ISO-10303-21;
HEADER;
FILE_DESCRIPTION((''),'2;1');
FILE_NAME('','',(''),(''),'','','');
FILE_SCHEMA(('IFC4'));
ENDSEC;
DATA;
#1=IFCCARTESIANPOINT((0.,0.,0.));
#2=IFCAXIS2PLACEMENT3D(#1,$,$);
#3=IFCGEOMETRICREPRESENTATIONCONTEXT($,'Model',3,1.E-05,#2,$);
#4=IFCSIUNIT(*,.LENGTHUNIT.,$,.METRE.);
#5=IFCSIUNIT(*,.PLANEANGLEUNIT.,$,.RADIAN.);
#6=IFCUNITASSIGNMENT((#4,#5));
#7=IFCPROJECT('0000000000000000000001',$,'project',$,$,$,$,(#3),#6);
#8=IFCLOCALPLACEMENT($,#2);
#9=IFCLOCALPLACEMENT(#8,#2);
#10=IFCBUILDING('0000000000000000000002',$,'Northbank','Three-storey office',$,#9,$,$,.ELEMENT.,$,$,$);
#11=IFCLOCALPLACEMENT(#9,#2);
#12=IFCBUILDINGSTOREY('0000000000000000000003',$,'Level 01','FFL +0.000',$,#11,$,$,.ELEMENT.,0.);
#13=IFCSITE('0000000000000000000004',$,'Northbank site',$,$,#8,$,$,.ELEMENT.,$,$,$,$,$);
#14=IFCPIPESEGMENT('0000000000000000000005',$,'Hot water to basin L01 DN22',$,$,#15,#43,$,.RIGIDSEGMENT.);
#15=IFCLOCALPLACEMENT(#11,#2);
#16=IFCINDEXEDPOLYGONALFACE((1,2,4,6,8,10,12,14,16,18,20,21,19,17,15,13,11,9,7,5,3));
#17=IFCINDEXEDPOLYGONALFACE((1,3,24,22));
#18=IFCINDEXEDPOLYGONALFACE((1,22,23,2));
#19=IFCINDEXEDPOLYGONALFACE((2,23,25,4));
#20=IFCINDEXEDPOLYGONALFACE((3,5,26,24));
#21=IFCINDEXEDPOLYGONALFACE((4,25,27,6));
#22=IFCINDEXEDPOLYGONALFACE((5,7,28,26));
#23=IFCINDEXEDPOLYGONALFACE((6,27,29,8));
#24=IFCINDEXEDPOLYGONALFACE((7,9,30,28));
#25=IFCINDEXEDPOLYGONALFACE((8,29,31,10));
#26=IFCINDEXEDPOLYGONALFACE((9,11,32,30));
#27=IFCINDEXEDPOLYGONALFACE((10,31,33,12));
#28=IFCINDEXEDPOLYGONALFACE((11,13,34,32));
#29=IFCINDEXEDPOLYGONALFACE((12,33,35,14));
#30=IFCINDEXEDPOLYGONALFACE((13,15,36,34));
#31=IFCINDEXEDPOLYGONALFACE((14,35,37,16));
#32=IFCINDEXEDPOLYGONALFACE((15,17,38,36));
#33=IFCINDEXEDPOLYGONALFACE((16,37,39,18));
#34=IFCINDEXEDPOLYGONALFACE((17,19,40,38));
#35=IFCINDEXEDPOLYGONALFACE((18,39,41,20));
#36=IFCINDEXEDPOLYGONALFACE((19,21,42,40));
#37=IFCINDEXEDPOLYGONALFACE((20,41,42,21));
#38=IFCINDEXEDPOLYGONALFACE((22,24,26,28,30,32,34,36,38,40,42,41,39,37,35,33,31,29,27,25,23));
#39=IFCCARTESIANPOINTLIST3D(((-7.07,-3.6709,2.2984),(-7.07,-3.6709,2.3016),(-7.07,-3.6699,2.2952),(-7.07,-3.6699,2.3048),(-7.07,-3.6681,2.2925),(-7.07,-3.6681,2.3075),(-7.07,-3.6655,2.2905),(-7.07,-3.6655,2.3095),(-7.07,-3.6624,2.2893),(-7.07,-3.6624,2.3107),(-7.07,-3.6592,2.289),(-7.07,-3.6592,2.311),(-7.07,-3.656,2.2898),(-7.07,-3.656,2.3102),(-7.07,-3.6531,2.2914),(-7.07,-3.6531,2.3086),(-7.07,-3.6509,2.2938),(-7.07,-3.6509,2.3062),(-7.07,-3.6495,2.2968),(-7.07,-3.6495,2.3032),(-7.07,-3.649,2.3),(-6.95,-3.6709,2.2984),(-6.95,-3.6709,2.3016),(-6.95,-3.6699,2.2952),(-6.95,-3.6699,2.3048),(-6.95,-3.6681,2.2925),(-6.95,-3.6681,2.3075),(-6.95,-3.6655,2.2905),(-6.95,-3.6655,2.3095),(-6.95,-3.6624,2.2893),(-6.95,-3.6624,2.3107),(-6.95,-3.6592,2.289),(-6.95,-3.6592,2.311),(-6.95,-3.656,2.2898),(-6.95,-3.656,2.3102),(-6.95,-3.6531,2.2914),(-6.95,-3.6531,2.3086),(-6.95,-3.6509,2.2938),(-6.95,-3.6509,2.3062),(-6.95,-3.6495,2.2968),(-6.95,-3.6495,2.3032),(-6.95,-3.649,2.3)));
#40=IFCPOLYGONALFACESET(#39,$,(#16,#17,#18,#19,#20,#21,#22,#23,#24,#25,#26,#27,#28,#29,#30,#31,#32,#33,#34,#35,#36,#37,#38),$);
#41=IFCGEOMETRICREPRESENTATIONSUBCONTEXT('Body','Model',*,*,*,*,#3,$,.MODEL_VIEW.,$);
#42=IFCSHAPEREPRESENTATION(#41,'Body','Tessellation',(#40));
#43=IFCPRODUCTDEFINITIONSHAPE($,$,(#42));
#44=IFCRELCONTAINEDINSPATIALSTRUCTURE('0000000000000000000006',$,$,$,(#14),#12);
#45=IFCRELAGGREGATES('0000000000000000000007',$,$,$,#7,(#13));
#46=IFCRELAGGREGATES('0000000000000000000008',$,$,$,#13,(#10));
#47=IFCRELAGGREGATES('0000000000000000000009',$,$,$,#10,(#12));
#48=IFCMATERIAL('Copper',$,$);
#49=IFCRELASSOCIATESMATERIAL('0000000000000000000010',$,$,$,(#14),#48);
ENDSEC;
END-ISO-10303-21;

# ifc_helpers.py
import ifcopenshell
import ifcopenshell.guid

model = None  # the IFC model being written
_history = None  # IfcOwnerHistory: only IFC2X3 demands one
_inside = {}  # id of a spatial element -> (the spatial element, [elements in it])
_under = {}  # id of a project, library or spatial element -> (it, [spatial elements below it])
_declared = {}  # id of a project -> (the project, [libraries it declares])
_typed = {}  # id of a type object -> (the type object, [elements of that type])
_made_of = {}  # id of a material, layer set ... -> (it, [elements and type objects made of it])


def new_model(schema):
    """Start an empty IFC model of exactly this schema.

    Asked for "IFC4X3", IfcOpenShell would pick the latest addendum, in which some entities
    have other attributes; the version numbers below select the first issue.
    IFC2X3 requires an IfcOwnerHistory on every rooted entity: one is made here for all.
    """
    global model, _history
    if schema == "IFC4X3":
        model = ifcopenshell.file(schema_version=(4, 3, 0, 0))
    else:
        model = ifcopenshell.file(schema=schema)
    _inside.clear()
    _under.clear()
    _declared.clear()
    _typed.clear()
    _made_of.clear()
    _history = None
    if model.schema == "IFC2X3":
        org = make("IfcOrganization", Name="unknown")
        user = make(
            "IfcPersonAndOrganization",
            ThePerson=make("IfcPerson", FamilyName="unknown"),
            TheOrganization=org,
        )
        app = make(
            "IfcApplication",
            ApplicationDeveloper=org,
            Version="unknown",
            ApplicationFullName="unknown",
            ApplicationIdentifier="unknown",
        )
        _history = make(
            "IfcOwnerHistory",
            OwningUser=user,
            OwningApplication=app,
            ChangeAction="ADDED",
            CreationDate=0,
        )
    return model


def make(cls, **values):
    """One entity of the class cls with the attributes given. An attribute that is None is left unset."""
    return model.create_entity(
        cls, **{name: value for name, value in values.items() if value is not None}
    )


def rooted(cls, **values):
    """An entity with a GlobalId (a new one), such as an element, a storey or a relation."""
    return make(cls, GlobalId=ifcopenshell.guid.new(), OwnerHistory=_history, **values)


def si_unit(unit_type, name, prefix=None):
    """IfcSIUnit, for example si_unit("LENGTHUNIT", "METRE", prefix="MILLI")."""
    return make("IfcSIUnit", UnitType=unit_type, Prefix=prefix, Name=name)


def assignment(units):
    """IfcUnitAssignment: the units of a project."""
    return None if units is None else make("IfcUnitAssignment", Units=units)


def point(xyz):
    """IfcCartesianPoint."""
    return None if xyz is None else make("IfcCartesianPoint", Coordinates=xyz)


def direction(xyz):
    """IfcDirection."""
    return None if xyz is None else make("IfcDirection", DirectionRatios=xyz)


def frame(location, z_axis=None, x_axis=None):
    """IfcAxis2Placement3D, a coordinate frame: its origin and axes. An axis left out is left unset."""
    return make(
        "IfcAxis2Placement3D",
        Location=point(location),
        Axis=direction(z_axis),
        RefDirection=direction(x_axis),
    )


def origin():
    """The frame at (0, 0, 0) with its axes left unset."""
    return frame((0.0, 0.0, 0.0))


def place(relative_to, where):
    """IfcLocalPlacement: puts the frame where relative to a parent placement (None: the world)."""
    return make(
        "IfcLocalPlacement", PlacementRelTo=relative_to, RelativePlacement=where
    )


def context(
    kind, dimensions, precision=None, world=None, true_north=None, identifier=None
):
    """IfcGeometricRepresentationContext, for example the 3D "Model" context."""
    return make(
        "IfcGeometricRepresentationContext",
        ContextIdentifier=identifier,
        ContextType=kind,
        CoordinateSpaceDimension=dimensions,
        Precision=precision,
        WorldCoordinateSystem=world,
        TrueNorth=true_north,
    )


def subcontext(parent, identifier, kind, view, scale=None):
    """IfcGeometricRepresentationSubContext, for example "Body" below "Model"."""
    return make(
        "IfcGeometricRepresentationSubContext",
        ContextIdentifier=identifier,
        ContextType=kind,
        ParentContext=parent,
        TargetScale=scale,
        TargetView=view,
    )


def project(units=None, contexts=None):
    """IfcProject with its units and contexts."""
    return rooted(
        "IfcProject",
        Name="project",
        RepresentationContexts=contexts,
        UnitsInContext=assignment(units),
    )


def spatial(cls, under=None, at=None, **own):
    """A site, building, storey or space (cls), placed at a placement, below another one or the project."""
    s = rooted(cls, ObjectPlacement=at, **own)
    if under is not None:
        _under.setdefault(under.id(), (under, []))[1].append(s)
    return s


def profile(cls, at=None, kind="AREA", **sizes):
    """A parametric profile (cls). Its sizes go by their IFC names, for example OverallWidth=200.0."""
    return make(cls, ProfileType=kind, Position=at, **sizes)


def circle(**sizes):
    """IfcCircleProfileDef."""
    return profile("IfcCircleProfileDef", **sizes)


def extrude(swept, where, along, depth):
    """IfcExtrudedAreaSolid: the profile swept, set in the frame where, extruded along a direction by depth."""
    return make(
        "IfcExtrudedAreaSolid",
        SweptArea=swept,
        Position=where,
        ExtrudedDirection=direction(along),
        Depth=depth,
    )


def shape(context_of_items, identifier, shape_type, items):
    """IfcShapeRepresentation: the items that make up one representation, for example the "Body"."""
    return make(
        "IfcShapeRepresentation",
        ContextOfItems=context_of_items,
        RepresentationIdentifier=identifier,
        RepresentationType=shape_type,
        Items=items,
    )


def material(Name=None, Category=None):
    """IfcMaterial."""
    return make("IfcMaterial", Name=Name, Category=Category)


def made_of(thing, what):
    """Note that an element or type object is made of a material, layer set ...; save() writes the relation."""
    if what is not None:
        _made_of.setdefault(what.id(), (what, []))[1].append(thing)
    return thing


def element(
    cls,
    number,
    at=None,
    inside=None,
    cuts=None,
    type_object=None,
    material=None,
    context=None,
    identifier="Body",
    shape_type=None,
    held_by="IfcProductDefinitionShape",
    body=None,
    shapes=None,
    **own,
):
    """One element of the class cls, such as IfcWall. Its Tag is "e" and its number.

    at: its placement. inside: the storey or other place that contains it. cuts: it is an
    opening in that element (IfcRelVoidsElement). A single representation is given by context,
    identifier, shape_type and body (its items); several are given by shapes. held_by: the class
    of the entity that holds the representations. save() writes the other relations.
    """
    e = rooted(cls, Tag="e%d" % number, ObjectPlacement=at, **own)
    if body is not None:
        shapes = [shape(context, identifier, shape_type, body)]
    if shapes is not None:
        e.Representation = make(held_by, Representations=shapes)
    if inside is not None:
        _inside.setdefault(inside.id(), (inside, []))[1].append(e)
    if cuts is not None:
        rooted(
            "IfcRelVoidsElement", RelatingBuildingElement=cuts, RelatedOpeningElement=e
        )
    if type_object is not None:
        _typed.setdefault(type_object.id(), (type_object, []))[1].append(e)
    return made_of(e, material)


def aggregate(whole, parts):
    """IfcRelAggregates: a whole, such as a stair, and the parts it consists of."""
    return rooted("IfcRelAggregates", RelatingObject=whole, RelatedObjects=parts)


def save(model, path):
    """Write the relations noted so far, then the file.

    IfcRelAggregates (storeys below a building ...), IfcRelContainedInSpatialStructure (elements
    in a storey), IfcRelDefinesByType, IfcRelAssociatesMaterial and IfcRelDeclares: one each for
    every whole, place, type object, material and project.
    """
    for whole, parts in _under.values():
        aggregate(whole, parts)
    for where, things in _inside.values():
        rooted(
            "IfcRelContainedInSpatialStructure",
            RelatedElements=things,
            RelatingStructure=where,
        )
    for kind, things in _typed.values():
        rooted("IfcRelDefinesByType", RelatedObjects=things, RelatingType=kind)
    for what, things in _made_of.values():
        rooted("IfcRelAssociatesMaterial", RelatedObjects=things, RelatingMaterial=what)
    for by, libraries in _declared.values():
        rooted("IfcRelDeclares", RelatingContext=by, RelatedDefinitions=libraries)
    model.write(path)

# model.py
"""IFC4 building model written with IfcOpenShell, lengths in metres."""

from ifc_helpers import new_model, si_unit, frame, origin, place, context, subcontext, project, spatial, circle, extrude, material, element, save


model = new_model("IFC4")

# Units and contexts
model_context = context("Model", 3, precision=1e-05, world=origin())
body_context = subcontext(model_context, "Body", "Model", "MODEL_VIEW")
ifc_project = project(units=[si_unit("LENGTHUNIT", "METRE"), si_unit("PLANEANGLEUNIT", "RADIAN")], contexts=[model_context])

# Site, building, storey
site_placement = place(None, origin())
site = spatial("IfcSite", under=ifc_project, at=site_placement, Name="Northbank site", CompositionType="ELEMENT")
building_placement = place(site_placement, origin())
building = spatial("IfcBuilding", under=site, at=building_placement, Name="Northbank", Description="Three-storey office", CompositionType="ELEMENT")
storey_placement = place(building_placement, origin())
storey = spatial("IfcBuildingStorey", under=building, at=storey_placement, Name="Level 01", Description="FFL +0.000", CompositionType="ELEMENT", Elevation=0.0)

# Shared definitions
ifc_material = material(Name="Copper")

# Pipe segment
pipe_segment_1_placement = place(storey_placement, origin())
element("IfcPipeSegment", 1, at=pipe_segment_1_placement, inside=storey, material=ifc_material, Name="Hot water to basin L01 DN22", PredefinedType="RIGIDSEGMENT", context=body_context, shape_type="SweptSolid", body=[
    extrude(circle(Radius=0.011), frame((-7.07, -3.66, 2.3), z_axis=(1.0, 0.0, 0.0), x_axis=(0.0, 1.0, 0.0)), (0.0, 0.0, 1.0), 0.12),
])

save(model, "model.ifc")
